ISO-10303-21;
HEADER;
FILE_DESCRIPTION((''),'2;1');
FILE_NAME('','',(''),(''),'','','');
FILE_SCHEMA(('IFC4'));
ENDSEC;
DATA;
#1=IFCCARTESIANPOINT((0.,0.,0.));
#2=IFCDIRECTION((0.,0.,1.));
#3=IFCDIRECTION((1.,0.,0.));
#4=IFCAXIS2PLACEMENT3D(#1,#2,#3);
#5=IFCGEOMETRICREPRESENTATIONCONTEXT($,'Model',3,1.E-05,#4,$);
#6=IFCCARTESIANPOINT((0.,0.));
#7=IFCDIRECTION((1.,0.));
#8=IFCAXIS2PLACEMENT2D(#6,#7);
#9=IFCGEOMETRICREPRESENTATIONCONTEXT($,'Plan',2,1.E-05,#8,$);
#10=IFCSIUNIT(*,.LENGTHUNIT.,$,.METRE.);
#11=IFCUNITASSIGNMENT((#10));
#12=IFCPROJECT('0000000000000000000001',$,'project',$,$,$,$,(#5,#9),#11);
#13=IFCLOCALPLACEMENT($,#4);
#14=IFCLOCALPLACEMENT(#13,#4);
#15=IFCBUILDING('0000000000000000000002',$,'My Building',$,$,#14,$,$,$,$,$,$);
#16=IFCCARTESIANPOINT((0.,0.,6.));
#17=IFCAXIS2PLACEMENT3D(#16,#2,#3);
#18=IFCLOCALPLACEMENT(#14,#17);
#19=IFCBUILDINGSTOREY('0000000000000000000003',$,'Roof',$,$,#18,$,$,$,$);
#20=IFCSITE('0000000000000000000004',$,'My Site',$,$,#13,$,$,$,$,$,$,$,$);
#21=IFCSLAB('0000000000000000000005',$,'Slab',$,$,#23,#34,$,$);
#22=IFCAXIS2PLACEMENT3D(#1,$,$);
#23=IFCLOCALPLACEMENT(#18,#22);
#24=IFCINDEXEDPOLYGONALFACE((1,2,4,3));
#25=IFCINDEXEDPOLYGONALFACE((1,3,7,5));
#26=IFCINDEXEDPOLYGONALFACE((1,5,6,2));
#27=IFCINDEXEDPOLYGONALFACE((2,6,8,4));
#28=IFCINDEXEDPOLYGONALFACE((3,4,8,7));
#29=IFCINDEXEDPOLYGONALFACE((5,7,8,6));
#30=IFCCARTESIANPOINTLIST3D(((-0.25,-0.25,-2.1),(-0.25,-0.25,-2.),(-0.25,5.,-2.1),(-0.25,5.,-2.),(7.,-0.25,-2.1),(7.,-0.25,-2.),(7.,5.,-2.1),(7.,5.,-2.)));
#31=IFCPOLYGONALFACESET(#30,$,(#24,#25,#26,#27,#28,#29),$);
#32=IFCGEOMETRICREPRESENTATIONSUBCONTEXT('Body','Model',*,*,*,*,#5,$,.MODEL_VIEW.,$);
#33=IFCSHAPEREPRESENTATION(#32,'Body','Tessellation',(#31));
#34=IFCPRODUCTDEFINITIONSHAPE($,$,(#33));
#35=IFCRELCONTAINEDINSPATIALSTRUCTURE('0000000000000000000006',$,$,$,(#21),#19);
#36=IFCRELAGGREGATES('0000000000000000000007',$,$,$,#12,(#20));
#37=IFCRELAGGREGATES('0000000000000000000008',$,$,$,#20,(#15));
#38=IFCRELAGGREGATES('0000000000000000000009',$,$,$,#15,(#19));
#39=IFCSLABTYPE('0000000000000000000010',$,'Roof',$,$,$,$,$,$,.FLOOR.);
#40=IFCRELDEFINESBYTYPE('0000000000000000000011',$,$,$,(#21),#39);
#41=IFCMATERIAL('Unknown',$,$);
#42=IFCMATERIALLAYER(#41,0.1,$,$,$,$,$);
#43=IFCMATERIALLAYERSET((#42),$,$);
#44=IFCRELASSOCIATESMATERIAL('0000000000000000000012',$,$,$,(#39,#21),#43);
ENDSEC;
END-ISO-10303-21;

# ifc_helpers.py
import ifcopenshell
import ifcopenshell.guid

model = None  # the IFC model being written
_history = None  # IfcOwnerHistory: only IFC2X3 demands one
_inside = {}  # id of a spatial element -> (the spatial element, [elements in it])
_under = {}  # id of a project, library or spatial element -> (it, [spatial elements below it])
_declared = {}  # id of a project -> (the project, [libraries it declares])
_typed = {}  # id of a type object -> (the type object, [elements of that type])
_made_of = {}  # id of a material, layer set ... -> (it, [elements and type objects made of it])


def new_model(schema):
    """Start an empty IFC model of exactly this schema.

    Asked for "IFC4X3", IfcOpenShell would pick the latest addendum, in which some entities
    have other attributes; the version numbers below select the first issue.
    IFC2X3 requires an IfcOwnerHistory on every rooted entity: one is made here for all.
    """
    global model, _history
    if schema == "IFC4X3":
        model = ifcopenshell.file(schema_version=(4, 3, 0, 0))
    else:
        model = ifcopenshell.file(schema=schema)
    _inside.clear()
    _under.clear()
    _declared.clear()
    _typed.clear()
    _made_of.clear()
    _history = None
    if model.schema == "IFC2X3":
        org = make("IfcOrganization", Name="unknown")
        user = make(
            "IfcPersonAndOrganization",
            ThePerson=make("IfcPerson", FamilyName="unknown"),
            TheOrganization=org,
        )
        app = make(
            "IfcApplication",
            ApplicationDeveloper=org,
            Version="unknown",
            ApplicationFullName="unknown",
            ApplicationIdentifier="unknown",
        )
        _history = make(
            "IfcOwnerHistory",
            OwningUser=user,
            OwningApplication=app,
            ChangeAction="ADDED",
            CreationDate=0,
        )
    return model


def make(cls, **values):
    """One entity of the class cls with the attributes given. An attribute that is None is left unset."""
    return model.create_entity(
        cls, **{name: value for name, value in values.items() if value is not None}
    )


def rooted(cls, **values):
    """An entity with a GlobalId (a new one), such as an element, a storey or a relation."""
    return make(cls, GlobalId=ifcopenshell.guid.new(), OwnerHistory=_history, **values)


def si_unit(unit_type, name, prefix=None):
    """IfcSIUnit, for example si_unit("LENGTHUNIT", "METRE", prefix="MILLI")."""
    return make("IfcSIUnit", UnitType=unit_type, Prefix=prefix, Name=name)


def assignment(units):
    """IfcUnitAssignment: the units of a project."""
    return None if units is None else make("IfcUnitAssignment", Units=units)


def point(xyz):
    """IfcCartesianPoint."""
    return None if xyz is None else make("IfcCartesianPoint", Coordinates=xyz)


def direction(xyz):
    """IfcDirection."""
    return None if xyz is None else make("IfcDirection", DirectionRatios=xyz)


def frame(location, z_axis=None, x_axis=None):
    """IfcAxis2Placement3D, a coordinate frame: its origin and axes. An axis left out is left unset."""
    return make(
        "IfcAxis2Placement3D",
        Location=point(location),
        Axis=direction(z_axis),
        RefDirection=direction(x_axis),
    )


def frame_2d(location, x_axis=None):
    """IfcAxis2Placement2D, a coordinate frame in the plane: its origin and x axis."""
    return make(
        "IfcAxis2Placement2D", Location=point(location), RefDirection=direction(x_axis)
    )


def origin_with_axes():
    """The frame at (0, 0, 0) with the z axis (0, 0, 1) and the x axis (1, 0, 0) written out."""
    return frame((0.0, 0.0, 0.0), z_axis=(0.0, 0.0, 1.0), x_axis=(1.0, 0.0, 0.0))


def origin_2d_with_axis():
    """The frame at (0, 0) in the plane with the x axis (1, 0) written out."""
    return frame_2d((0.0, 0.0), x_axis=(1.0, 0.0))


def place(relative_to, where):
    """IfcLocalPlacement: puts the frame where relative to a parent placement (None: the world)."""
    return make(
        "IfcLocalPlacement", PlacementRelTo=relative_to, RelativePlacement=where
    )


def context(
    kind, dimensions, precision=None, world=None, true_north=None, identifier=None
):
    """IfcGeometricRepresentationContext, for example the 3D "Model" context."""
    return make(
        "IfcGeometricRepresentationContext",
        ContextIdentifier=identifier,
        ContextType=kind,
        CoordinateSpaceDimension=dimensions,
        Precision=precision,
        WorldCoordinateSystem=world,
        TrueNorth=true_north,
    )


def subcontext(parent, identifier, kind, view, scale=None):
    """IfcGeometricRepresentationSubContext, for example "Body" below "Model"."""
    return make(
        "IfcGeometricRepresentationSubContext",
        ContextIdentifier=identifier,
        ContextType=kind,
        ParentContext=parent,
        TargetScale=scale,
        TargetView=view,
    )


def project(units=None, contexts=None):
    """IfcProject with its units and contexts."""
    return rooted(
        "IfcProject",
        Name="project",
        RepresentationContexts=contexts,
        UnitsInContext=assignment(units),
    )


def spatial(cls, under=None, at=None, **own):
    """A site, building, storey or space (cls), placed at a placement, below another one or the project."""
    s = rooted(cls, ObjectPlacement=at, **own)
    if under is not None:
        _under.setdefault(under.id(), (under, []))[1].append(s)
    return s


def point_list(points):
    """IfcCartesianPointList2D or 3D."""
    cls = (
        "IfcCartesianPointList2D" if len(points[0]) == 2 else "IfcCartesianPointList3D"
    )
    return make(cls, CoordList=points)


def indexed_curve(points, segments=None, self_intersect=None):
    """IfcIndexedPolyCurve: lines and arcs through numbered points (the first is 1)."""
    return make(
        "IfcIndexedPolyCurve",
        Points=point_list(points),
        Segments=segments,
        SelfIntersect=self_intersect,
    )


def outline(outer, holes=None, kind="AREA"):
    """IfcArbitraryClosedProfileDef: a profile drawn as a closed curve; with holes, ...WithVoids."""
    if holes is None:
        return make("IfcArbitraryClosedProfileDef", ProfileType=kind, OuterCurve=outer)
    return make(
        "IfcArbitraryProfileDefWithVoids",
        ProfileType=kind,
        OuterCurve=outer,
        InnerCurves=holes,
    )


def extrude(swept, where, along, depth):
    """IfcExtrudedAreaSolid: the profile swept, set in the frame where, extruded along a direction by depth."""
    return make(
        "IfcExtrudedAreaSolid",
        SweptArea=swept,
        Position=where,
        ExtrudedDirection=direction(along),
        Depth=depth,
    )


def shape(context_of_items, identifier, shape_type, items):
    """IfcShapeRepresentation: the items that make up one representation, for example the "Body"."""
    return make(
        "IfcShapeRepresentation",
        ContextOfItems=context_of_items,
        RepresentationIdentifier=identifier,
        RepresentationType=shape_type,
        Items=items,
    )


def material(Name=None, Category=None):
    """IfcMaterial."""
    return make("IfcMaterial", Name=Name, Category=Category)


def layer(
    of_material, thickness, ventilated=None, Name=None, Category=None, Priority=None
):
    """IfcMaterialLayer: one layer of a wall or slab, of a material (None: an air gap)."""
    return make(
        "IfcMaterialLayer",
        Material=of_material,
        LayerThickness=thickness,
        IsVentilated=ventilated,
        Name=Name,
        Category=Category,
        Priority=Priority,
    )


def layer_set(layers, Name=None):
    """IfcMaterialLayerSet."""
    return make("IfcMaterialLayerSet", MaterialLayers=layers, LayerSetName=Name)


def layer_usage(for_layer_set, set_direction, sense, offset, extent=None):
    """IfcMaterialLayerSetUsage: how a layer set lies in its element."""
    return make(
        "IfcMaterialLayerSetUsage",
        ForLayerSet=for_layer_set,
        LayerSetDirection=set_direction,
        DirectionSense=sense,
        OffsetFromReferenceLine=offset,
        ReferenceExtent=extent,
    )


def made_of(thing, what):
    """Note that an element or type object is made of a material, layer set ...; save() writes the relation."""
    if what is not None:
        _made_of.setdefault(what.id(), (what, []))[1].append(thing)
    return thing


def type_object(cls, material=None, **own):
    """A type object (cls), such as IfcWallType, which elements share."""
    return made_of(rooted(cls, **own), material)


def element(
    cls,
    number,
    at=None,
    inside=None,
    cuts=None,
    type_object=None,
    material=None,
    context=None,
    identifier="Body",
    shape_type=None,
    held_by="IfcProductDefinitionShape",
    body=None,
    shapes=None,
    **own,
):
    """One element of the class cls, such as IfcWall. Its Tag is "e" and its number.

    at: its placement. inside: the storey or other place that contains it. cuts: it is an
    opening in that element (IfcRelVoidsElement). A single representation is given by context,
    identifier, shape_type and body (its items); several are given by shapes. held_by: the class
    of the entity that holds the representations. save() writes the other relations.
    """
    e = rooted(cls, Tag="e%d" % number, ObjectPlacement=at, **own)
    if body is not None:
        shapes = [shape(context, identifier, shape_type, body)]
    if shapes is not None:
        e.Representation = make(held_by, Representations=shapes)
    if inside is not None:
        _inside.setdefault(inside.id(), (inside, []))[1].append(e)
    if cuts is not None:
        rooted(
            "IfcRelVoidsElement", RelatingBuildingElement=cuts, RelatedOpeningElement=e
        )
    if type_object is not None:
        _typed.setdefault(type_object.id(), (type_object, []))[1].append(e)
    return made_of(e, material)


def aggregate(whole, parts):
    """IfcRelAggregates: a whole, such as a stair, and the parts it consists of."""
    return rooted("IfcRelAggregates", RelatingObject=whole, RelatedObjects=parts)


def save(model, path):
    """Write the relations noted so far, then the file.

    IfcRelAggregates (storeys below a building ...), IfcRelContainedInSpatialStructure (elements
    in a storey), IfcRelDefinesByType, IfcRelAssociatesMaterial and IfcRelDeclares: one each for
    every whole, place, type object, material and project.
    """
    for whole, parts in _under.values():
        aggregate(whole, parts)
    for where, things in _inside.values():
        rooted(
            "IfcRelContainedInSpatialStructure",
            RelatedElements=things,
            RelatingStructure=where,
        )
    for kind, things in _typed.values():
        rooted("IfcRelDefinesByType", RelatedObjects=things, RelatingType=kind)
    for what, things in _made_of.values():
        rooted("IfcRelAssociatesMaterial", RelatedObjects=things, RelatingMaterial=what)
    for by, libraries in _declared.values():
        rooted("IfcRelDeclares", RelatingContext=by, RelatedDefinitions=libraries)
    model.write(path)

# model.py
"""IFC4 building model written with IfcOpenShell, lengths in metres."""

from ifc_helpers import new_model, si_unit, frame, origin_with_axes, origin_2d_with_axis, place, context, subcontext, project, spatial, indexed_curve, outline, extrude, material, layer, layer_set, layer_usage, type_object, element, save


model = new_model("IFC4")

# Units and contexts
model_context = context("Model", 3, precision=1e-05, world=origin_with_axes())
plan_context = context("Plan", 2, precision=1e-05, world=origin_2d_with_axis())
body_context = subcontext(model_context, "Body", "Model", "MODEL_VIEW")
ifc_project = project(units=[si_unit("LENGTHUNIT", "METRE")], contexts=[model_context, plan_context])

# Site, building, storey
site_placement = place(None, origin_with_axes())
site = spatial("IfcSite", under=ifc_project, at=site_placement, Name="My Site")
building_placement = place(site_placement, origin_with_axes())
building = spatial("IfcBuilding", under=site, at=building_placement, Name="My Building")
storey_placement = place(building_placement, frame((0.0, 0.0, 6.0), z_axis=(0.0, 0.0, 1.0), x_axis=(1.0, 0.0, 0.0)))
storey = spatial("IfcBuildingStorey", under=building, at=storey_placement, Name="Roof")

# Slab
ifc_material = material(Name="Unknown")
ifc_layer = layer(ifc_material, 0.1)
ifc_layer_set = layer_set([ifc_layer])
ifc_layer_usage = layer_usage(ifc_layer_set, "AXIS3", "POSITIVE", -0.1)
slab_type = type_object("IfcSlabType", Name="Roof", PredefinedType="FLOOR", material=ifc_layer_set)
slab_placement = place(storey_placement, frame((-0.25, -0.25, -2.0), z_axis=(0.0, 0.0, 1.0), x_axis=(1.0, 0.0, 0.0)))
element("IfcSlab", 1, at=slab_placement, inside=storey, type_object=slab_type, material=ifc_layer_usage, Name="Slab", context=body_context, shape_type="SweptSolid", body=[
    extrude(outline(indexed_curve([(0.0, 0.0), (7.25, 0.0), (7.25, 5.25), (0.0, 5.25), (0.0, 0.0)])), frame((0.0, 0.0, -0.1), z_axis=(0.0, 0.0, 1.0), x_axis=(1.0, 0.0, 0.0)), (0.0, 0.0, 1.0), 0.1),
])

save(model, "model.ifc")
